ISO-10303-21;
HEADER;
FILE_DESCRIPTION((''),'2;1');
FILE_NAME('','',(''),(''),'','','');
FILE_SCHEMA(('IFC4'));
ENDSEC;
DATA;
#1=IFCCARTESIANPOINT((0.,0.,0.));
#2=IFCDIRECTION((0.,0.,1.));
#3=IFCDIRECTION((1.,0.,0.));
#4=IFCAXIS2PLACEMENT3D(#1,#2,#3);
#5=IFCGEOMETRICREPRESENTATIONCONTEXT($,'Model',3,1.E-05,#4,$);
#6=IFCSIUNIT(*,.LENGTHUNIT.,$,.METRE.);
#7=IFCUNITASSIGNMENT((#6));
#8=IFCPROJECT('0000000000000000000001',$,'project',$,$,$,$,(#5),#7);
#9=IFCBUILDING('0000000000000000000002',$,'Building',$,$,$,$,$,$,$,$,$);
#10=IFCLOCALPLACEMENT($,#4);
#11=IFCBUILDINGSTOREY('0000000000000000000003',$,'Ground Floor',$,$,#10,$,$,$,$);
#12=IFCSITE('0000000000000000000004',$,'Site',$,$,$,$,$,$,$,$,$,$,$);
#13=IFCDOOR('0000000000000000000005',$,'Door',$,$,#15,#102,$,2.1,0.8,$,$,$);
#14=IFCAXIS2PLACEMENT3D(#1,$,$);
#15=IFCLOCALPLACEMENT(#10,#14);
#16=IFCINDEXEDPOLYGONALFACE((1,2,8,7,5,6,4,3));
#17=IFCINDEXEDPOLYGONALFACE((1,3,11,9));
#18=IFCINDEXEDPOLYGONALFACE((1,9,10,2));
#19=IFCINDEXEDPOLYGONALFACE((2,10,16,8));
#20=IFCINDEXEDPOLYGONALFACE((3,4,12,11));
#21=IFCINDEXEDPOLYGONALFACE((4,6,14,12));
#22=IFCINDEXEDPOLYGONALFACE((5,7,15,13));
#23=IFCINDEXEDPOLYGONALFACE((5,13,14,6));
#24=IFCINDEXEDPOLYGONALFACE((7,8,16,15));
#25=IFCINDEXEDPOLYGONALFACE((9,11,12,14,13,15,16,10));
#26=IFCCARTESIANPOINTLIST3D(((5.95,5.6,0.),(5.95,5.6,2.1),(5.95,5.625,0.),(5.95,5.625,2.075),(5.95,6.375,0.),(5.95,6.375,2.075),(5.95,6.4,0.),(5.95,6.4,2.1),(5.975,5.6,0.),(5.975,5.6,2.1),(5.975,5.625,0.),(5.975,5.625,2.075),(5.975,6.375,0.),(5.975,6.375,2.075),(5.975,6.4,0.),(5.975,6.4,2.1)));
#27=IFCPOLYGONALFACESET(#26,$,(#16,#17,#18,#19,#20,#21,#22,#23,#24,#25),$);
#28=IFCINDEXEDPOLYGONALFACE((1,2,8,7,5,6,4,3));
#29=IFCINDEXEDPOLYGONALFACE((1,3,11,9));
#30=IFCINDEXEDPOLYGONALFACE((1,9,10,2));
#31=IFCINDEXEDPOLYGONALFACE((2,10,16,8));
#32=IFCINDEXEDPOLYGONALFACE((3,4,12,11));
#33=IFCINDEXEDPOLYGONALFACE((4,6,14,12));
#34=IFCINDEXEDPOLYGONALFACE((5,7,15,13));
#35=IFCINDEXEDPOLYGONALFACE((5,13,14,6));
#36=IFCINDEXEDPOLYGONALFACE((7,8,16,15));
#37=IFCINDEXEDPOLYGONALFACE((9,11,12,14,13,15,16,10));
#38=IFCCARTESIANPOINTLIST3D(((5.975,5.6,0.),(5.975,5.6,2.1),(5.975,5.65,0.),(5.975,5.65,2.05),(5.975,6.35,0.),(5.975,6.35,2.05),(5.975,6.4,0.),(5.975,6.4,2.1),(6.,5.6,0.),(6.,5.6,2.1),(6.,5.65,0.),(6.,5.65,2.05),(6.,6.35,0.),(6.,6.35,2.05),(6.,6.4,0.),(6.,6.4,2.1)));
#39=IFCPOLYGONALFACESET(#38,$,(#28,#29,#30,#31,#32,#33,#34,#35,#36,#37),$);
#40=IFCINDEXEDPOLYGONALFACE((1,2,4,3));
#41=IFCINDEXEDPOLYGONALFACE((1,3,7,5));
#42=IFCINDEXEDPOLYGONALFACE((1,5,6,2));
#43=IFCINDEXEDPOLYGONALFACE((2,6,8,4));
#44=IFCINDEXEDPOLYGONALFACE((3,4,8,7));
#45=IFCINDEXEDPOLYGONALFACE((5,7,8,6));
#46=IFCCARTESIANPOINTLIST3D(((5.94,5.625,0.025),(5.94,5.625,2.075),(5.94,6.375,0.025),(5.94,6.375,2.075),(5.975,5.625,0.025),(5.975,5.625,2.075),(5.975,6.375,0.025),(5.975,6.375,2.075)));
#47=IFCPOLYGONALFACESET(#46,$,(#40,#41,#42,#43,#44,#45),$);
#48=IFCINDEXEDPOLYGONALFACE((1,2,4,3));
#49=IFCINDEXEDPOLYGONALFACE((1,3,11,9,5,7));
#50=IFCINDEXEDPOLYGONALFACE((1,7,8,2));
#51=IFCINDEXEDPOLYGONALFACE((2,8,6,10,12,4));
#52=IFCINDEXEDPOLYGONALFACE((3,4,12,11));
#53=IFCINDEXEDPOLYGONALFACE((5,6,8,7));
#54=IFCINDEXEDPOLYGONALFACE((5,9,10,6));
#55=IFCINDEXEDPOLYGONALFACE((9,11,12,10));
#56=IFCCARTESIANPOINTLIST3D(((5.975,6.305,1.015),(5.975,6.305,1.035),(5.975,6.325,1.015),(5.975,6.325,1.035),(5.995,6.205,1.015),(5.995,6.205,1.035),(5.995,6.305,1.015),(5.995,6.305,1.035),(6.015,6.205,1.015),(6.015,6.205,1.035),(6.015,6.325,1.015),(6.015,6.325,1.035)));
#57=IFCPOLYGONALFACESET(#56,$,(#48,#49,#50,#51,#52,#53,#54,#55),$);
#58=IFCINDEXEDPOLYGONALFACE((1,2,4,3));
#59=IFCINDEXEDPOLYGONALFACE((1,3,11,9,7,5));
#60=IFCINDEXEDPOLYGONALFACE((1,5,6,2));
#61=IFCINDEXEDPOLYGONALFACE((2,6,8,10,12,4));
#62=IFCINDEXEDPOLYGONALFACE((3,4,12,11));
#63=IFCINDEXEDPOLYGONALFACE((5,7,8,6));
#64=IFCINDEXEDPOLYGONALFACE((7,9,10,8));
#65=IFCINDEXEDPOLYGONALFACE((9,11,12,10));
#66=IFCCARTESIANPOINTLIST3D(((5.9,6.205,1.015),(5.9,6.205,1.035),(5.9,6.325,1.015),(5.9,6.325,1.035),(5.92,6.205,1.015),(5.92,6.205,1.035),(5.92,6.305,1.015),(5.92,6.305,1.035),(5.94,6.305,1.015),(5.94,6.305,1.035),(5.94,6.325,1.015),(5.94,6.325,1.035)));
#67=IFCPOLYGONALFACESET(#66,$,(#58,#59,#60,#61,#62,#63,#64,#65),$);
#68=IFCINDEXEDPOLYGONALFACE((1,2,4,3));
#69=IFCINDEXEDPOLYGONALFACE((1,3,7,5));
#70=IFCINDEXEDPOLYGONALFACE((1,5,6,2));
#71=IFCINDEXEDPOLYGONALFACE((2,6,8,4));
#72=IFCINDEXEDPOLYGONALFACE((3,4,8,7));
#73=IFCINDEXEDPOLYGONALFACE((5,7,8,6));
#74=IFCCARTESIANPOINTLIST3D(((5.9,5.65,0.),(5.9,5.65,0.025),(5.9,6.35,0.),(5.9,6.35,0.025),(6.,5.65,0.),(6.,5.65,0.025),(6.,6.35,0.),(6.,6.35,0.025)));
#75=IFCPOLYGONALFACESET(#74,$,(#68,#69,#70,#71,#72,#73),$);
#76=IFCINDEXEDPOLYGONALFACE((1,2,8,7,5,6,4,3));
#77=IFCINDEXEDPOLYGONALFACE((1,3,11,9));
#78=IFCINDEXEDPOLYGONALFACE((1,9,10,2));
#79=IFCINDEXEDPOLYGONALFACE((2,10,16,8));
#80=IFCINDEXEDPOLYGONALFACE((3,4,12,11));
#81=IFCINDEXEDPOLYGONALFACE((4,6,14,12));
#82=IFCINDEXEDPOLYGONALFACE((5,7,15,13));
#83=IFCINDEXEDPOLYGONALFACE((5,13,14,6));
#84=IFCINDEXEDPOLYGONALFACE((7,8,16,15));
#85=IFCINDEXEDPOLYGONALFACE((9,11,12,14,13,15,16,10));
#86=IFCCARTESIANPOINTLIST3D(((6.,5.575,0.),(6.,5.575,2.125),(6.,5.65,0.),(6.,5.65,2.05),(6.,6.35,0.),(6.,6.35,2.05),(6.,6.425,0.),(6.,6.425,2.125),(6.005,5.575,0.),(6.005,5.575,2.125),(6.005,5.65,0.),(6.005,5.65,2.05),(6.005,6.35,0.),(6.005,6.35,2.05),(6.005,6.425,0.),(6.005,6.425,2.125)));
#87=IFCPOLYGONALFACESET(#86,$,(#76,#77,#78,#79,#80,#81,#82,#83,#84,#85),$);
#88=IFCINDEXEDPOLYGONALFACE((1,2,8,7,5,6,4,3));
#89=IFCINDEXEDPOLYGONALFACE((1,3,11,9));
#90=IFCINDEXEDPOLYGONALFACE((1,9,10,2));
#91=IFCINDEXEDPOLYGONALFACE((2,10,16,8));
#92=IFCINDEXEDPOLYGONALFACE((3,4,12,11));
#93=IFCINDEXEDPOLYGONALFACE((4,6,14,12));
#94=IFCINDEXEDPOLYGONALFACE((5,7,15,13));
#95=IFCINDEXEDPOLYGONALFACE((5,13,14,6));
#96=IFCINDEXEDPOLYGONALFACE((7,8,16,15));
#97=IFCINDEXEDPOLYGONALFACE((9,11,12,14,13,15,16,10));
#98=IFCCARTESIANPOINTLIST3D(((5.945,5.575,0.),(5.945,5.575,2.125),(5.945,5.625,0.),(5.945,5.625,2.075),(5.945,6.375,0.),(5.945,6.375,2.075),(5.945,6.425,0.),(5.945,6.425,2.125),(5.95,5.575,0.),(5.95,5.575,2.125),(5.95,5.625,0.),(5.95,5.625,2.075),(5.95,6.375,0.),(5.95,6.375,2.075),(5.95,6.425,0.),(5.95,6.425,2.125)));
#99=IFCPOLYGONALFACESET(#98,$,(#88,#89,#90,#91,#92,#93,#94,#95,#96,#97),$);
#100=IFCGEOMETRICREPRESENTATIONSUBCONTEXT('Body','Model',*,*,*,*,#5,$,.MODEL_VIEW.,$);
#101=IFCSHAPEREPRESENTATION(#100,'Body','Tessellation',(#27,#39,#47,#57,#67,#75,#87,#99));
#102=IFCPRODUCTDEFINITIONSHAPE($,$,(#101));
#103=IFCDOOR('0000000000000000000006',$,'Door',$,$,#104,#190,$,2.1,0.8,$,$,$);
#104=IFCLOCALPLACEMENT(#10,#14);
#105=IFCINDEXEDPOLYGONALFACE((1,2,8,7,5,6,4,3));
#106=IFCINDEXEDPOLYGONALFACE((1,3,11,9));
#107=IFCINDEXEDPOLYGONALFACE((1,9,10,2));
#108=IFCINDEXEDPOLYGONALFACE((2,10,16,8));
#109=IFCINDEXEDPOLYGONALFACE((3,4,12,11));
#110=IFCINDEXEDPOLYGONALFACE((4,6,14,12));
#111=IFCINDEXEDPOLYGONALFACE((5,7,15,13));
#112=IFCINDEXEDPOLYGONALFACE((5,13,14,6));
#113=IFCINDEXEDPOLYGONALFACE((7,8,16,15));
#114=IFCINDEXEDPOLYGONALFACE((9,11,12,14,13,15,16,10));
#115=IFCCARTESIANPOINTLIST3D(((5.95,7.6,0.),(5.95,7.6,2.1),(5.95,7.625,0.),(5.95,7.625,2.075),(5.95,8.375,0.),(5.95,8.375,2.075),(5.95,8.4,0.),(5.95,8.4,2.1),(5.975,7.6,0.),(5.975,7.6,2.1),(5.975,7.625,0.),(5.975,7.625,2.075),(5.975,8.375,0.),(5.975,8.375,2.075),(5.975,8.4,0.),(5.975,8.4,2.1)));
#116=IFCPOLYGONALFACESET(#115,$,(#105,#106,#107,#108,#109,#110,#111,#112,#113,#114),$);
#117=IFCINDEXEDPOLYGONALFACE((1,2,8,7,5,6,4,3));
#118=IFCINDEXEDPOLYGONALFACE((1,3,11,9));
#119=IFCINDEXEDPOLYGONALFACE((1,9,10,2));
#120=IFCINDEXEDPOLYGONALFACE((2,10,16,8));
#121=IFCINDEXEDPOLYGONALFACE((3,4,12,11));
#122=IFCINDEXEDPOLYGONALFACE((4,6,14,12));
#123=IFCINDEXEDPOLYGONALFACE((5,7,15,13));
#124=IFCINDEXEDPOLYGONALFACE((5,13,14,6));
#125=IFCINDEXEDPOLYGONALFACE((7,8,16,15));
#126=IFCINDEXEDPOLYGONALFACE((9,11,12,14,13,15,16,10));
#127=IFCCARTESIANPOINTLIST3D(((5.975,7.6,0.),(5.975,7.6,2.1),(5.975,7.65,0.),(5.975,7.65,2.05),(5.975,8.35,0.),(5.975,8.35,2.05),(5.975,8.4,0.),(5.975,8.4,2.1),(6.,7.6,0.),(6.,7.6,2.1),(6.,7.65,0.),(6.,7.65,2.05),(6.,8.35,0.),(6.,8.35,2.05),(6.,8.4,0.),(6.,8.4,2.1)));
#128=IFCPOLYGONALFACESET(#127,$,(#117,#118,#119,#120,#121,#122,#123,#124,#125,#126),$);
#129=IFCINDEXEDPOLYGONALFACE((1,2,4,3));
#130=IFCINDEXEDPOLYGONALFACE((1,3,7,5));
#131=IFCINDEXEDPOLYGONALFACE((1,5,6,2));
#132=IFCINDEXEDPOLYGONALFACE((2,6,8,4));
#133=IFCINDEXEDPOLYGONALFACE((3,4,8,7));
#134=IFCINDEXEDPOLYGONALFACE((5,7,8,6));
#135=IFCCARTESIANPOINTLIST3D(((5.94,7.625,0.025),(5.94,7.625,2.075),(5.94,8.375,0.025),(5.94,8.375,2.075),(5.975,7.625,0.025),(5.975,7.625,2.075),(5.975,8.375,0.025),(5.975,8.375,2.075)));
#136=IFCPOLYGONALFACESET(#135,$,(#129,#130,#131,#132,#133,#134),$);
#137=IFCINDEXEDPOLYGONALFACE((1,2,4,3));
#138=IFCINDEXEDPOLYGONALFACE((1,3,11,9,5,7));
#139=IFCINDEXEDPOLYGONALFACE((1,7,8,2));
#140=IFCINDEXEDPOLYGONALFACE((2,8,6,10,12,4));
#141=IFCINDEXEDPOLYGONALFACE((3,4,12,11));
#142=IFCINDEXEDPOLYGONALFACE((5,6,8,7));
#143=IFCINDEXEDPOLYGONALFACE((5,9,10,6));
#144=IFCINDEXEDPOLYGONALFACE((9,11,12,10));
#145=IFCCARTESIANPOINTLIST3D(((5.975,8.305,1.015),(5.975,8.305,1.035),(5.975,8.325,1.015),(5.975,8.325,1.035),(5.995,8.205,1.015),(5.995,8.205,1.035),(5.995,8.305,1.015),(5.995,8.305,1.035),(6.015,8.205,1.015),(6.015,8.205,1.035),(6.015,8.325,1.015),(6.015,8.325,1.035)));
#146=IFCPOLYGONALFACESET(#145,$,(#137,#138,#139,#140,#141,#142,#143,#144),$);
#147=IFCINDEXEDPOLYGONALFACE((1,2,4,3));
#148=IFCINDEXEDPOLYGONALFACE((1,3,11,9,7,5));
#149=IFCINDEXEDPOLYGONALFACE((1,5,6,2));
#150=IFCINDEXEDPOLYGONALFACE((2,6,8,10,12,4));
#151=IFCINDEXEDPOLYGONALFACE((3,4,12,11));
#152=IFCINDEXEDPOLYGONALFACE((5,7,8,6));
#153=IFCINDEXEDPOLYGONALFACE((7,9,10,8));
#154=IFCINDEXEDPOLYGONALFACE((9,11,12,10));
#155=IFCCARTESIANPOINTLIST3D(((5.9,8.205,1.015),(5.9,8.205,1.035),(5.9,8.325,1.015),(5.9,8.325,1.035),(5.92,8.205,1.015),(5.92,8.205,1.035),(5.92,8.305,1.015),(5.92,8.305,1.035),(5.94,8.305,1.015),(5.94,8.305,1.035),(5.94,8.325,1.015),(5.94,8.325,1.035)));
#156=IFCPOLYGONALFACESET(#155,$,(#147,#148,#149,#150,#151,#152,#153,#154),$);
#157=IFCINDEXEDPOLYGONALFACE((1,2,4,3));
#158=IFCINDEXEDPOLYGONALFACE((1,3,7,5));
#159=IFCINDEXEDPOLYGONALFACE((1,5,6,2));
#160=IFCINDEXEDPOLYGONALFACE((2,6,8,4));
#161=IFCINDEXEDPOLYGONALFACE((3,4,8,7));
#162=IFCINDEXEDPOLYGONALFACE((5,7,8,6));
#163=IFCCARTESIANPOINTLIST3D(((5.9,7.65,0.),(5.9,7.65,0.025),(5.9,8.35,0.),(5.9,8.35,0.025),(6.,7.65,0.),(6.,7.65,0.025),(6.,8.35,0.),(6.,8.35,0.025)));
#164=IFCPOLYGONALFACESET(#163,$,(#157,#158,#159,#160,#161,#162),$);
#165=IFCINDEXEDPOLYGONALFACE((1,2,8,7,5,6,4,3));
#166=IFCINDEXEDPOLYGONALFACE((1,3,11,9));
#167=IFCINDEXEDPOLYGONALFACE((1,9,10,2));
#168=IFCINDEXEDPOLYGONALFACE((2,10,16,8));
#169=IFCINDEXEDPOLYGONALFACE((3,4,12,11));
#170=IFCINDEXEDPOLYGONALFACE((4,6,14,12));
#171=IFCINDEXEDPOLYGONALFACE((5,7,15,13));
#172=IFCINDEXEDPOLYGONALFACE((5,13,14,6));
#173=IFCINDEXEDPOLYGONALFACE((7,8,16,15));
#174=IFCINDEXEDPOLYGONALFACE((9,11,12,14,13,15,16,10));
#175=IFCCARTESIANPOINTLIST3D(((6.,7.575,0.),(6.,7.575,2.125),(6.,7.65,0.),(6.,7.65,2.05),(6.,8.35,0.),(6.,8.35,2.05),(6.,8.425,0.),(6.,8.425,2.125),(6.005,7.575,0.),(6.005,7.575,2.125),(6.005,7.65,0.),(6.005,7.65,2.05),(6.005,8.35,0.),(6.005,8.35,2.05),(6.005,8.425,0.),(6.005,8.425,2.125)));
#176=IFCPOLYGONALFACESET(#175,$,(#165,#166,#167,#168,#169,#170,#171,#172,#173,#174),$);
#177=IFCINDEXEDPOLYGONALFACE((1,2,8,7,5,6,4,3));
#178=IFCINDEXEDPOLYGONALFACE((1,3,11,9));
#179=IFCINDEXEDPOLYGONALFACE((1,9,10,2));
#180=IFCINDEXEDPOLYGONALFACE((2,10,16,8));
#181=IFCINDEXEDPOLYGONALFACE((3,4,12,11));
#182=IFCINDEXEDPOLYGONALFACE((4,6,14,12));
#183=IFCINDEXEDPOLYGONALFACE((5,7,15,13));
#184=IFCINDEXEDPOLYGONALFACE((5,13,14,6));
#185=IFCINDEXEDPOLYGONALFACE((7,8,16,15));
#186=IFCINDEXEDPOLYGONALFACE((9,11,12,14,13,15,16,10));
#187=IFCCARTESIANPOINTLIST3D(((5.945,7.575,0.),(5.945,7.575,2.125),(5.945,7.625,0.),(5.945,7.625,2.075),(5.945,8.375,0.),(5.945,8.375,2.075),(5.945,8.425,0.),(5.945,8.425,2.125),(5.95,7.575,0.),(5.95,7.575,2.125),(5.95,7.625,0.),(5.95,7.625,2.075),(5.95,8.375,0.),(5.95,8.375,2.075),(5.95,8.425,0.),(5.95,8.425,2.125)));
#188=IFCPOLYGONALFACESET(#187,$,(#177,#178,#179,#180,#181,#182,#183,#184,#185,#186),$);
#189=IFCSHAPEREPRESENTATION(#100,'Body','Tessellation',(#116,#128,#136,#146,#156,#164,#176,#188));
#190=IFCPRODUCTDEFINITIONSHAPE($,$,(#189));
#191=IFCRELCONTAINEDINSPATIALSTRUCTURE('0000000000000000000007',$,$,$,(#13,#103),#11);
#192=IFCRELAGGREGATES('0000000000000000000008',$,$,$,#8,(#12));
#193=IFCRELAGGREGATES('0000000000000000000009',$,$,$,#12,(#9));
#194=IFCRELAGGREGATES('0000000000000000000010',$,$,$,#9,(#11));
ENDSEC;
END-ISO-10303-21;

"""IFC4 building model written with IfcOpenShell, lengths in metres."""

from ifc_helpers import new_model, si_unit, frame, origin_with_axes, place, context, subcontext, project, spatial, line, indexed_curve, outline, extrude, element, save


model = new_model("IFC4")

# Units and contexts
model_context = context("Model", 3, precision=1e-05, world=origin_with_axes())
body_context = subcontext(model_context, "Body", "Model", "MODEL_VIEW")
ifc_project = project(units=[si_unit("LENGTHUNIT", "METRE")], contexts=[model_context])

# Site, building, storey
site = spatial("IfcSite", under=ifc_project, Name="Site")
building = spatial("IfcBuilding", under=site, Name="Building")
storey_placement = place(None, origin_with_axes())
storey = spatial("IfcBuildingStorey", under=building, at=storey_placement, Name="Ground Floor")

# Doors
door_1_placement = place(storey_placement, frame((6.0, 5.6, 0.0), z_axis=(0.0, 0.0, 1.0), x_axis=(0.0, 1.0, 0.0)))
element("IfcDoor", 1, at=door_1_placement, inside=storey, Name="Door", OverallHeight=2.1, OverallWidth=0.8, context=body_context, shape_type="SweptSolid", body=[
    extrude(outline(indexed_curve([(0.0, 0.0), (0.0, 2.1), (0.8, 2.1), (0.8, 0.0), (0.775, 0.0), (0.775, 2.075), (0.025, 2.075), (0.025, 0.0)], segments=[line(1, 2, 3, 4, 5, 6, 7, 8, 1)])), frame((0.0, 0.025, 0.0), z_axis=(0.0, -1.0, 0.0), x_axis=(1.0, 0.0, 0.0)), (0.0, 0.0, -1.0), 0.025),
    extrude(outline(indexed_curve([(0.0, 0.0), (0.0, 2.1), (0.8, 2.1), (0.8, 0.0), (0.75, 0.0), (0.75, 2.05), (0.05, 2.05), (0.05, 0.0)], segments=[line(1, 2, 3, 4, 5, 6, 7, 8, 1)])), frame((0.0, 0.0, 0.0), z_axis=(0.0, -1.0, 0.0), x_axis=(1.0, 0.0, 0.0)), (0.0, 0.0, -1.0), 0.025),
    extrude(outline(indexed_curve([(0.0, 0.0), (0.75, 0.0), (0.75, 0.035), (0.0, 0.035)], segments=[line(1, 2, 3, 4, 1)])), frame((0.025, 0.025, 0.025), z_axis=(0.0, 0.0, 1.0), x_axis=(1.0, 0.0, 0.0)), (0.0, 0.0, 1.0), 2.05),
    extrude(outline(indexed_curve([(0.0, 0.0), (0.0, -0.04), (-0.12, -0.04), (-0.12, -0.02), (-0.02, -0.02), (-0.02, 0.0)], segments=[line(1, 2, 3, 4, 5, 6, 1)])), frame((0.725, 0.025, 1.015), z_axis=(0.0, 0.0, 1.0), x_axis=(1.0, 0.0, 0.0)), (0.0, 0.0, 1.0), 0.02),
    extrude(outline(indexed_curve([(0.0, 0.0), (0.0, 0.04), (-0.12, 0.04), (-0.12, 0.02), (-0.02, 0.02), (-0.02, 0.0)], segments=[line(1, 2, 3, 4, 5, 6, 1)])), frame((0.725, 0.06, 1.015), z_axis=(0.0, 0.0, 1.0), x_axis=(1.0, 0.0, 0.0)), (0.0, 0.0, 1.0), 0.02),
    extrude(outline(indexed_curve([(0.0, 0.0), (0.7, 0.0), (0.7, 0.1), (0.0, 0.1)], segments=[line(1, 2, 3, 4, 1)])), frame((0.05, 0.0, 0.0), z_axis=(0.0, 0.0, 1.0), x_axis=(1.0, 0.0, 0.0)), (0.0, 0.0, 1.0), 0.025),
    extrude(outline(indexed_curve([(0.0, 0.0), (0.0, 2.125), (0.85, 2.125), (0.85, 0.0), (0.775, 0.0), (0.775, 2.05), (0.075, 2.05), (0.075, 0.0)], segments=[line(1, 2, 3, 4, 5, 6, 7, 8, 1)])), frame((-0.025, -0.005, 0.0), z_axis=(0.0, -1.0, 0.0), x_axis=(1.0, 0.0, 0.0)), (0.0, 0.0, -1.0), 0.005),
    extrude(outline(indexed_curve([(0.0, 0.0), (0.0, 2.125), (0.85, 2.125), (0.85, 0.0), (0.8, 0.0), (0.8, 2.075), (0.05, 2.075), (0.05, 0.0)], segments=[line(1, 2, 3, 4, 5, 6, 7, 8, 1)])), frame((-0.025, 0.05, 0.0), z_axis=(0.0, -1.0, 0.0), x_axis=(1.0, 0.0, 0.0)), (0.0, 0.0, -1.0), 0.005),
])
door_2_placement = place(storey_placement, frame((6.0, 7.6, 0.0), z_axis=(0.0, 0.0, 1.0), x_axis=(0.0, 1.0, 0.0)))
element("IfcDoor", 2, at=door_2_placement, inside=storey, Name="Door", OverallHeight=2.1, OverallWidth=0.8, context=body_context, shape_type="SweptSolid", body=[
    extrude(outline(indexed_curve([(0.0, 0.0), (0.0, 2.1), (0.8, 2.1), (0.8, 0.0), (0.775, 0.0), (0.775, 2.075), (0.025, 2.075), (0.025, 0.0)], segments=[line(1, 2, 3, 4, 5, 6, 7, 8, 1)])), frame((0.0, 0.025, 0.0), z_axis=(0.0, -1.0, 0.0), x_axis=(1.0, 0.0, 0.0)), (0.0, 0.0, -1.0), 0.025),
    extrude(outline(indexed_curve([(0.0, 0.0), (0.0, 2.1), (0.8, 2.1), (0.8, 0.0), (0.75, 0.0), (0.75, 2.05), (0.05, 2.05), (0.05, 0.0)], segments=[line(1, 2, 3, 4, 5, 6, 7, 8, 1)])), frame((0.0, 0.0, 0.0), z_axis=(0.0, -1.0, 0.0), x_axis=(1.0, 0.0, 0.0)), (0.0, 0.0, -1.0), 0.025),
    extrude(outline(indexed_curve([(0.0, 0.0), (0.75, 0.0), (0.75, 0.035), (0.0, 0.035)], segments=[line(1, 2, 3, 4, 1)])), frame((0.025, 0.025, 0.025), z_axis=(0.0, 0.0, 1.0), x_axis=(1.0, 0.0, 0.0)), (0.0, 0.0, 1.0), 2.05),
    extrude(outline(indexed_curve([(0.0, 0.0), (0.0, -0.04), (-0.12, -0.04), (-0.12, -0.02), (-0.02, -0.02), (-0.02, 0.0)], segments=[line(1, 2, 3, 4, 5, 6, 1)])), frame((0.725, 0.025, 1.015), z_axis=(0.0, 0.0, 1.0), x_axis=(1.0, 0.0, 0.0)), (0.0, 0.0, 1.0), 0.02),
    extrude(outline(indexed_curve([(0.0, 0.0), (0.0, 0.04), (-0.12, 0.04), (-0.12, 0.02), (-0.02, 0.02), (-0.02, 0.0)], segments=[line(1, 2, 3, 4, 5, 6, 1)])), frame((0.725, 0.06, 1.015), z_axis=(0.0, 0.0, 1.0), x_axis=(1.0, 0.0, 0.0)), (0.0, 0.0, 1.0), 0.02),
    extrude(outline(indexed_curve([(0.0, 0.0), (0.7, 0.0), (0.7, 0.1), (0.0, 0.1)], segments=[line(1, 2, 3, 4, 1)])), frame((0.05, 0.0, 0.0), z_axis=(0.0, 0.0, 1.0), x_axis=(1.0, 0.0, 0.0)), (0.0, 0.0, 1.0), 0.025),
    extrude(outline(indexed_curve([(0.0, 0.0), (0.0, 2.125), (0.85, 2.125), (0.85, 0.0), (0.775, 0.0), (0.775, 2.05), (0.075, 2.05), (0.075, 0.0)], segments=[line(1, 2, 3, 4, 5, 6, 7, 8, 1)])), frame((-0.025, -0.005, 0.0), z_axis=(0.0, -1.0, 0.0), x_axis=(1.0, 0.0, 0.0)), (0.0, 0.0, -1.0), 0.005),
    extrude(outline(indexed_curve([(0.0, 0.0), (0.0, 2.125), (0.85, 2.125), (0.85, 0.0), (0.8, 0.0), (0.8, 2.075), (0.05, 2.075), (0.05, 0.0)], segments=[line(1, 2, 3, 4, 5, 6, 7, 8, 1)])), frame((-0.025, 0.05, 0.0), z_axis=(0.0, -1.0, 0.0), x_axis=(1.0, 0.0, 0.0)), (0.0, 0.0, -1.0), 0.005),
])

save(model, "model.ifc")
